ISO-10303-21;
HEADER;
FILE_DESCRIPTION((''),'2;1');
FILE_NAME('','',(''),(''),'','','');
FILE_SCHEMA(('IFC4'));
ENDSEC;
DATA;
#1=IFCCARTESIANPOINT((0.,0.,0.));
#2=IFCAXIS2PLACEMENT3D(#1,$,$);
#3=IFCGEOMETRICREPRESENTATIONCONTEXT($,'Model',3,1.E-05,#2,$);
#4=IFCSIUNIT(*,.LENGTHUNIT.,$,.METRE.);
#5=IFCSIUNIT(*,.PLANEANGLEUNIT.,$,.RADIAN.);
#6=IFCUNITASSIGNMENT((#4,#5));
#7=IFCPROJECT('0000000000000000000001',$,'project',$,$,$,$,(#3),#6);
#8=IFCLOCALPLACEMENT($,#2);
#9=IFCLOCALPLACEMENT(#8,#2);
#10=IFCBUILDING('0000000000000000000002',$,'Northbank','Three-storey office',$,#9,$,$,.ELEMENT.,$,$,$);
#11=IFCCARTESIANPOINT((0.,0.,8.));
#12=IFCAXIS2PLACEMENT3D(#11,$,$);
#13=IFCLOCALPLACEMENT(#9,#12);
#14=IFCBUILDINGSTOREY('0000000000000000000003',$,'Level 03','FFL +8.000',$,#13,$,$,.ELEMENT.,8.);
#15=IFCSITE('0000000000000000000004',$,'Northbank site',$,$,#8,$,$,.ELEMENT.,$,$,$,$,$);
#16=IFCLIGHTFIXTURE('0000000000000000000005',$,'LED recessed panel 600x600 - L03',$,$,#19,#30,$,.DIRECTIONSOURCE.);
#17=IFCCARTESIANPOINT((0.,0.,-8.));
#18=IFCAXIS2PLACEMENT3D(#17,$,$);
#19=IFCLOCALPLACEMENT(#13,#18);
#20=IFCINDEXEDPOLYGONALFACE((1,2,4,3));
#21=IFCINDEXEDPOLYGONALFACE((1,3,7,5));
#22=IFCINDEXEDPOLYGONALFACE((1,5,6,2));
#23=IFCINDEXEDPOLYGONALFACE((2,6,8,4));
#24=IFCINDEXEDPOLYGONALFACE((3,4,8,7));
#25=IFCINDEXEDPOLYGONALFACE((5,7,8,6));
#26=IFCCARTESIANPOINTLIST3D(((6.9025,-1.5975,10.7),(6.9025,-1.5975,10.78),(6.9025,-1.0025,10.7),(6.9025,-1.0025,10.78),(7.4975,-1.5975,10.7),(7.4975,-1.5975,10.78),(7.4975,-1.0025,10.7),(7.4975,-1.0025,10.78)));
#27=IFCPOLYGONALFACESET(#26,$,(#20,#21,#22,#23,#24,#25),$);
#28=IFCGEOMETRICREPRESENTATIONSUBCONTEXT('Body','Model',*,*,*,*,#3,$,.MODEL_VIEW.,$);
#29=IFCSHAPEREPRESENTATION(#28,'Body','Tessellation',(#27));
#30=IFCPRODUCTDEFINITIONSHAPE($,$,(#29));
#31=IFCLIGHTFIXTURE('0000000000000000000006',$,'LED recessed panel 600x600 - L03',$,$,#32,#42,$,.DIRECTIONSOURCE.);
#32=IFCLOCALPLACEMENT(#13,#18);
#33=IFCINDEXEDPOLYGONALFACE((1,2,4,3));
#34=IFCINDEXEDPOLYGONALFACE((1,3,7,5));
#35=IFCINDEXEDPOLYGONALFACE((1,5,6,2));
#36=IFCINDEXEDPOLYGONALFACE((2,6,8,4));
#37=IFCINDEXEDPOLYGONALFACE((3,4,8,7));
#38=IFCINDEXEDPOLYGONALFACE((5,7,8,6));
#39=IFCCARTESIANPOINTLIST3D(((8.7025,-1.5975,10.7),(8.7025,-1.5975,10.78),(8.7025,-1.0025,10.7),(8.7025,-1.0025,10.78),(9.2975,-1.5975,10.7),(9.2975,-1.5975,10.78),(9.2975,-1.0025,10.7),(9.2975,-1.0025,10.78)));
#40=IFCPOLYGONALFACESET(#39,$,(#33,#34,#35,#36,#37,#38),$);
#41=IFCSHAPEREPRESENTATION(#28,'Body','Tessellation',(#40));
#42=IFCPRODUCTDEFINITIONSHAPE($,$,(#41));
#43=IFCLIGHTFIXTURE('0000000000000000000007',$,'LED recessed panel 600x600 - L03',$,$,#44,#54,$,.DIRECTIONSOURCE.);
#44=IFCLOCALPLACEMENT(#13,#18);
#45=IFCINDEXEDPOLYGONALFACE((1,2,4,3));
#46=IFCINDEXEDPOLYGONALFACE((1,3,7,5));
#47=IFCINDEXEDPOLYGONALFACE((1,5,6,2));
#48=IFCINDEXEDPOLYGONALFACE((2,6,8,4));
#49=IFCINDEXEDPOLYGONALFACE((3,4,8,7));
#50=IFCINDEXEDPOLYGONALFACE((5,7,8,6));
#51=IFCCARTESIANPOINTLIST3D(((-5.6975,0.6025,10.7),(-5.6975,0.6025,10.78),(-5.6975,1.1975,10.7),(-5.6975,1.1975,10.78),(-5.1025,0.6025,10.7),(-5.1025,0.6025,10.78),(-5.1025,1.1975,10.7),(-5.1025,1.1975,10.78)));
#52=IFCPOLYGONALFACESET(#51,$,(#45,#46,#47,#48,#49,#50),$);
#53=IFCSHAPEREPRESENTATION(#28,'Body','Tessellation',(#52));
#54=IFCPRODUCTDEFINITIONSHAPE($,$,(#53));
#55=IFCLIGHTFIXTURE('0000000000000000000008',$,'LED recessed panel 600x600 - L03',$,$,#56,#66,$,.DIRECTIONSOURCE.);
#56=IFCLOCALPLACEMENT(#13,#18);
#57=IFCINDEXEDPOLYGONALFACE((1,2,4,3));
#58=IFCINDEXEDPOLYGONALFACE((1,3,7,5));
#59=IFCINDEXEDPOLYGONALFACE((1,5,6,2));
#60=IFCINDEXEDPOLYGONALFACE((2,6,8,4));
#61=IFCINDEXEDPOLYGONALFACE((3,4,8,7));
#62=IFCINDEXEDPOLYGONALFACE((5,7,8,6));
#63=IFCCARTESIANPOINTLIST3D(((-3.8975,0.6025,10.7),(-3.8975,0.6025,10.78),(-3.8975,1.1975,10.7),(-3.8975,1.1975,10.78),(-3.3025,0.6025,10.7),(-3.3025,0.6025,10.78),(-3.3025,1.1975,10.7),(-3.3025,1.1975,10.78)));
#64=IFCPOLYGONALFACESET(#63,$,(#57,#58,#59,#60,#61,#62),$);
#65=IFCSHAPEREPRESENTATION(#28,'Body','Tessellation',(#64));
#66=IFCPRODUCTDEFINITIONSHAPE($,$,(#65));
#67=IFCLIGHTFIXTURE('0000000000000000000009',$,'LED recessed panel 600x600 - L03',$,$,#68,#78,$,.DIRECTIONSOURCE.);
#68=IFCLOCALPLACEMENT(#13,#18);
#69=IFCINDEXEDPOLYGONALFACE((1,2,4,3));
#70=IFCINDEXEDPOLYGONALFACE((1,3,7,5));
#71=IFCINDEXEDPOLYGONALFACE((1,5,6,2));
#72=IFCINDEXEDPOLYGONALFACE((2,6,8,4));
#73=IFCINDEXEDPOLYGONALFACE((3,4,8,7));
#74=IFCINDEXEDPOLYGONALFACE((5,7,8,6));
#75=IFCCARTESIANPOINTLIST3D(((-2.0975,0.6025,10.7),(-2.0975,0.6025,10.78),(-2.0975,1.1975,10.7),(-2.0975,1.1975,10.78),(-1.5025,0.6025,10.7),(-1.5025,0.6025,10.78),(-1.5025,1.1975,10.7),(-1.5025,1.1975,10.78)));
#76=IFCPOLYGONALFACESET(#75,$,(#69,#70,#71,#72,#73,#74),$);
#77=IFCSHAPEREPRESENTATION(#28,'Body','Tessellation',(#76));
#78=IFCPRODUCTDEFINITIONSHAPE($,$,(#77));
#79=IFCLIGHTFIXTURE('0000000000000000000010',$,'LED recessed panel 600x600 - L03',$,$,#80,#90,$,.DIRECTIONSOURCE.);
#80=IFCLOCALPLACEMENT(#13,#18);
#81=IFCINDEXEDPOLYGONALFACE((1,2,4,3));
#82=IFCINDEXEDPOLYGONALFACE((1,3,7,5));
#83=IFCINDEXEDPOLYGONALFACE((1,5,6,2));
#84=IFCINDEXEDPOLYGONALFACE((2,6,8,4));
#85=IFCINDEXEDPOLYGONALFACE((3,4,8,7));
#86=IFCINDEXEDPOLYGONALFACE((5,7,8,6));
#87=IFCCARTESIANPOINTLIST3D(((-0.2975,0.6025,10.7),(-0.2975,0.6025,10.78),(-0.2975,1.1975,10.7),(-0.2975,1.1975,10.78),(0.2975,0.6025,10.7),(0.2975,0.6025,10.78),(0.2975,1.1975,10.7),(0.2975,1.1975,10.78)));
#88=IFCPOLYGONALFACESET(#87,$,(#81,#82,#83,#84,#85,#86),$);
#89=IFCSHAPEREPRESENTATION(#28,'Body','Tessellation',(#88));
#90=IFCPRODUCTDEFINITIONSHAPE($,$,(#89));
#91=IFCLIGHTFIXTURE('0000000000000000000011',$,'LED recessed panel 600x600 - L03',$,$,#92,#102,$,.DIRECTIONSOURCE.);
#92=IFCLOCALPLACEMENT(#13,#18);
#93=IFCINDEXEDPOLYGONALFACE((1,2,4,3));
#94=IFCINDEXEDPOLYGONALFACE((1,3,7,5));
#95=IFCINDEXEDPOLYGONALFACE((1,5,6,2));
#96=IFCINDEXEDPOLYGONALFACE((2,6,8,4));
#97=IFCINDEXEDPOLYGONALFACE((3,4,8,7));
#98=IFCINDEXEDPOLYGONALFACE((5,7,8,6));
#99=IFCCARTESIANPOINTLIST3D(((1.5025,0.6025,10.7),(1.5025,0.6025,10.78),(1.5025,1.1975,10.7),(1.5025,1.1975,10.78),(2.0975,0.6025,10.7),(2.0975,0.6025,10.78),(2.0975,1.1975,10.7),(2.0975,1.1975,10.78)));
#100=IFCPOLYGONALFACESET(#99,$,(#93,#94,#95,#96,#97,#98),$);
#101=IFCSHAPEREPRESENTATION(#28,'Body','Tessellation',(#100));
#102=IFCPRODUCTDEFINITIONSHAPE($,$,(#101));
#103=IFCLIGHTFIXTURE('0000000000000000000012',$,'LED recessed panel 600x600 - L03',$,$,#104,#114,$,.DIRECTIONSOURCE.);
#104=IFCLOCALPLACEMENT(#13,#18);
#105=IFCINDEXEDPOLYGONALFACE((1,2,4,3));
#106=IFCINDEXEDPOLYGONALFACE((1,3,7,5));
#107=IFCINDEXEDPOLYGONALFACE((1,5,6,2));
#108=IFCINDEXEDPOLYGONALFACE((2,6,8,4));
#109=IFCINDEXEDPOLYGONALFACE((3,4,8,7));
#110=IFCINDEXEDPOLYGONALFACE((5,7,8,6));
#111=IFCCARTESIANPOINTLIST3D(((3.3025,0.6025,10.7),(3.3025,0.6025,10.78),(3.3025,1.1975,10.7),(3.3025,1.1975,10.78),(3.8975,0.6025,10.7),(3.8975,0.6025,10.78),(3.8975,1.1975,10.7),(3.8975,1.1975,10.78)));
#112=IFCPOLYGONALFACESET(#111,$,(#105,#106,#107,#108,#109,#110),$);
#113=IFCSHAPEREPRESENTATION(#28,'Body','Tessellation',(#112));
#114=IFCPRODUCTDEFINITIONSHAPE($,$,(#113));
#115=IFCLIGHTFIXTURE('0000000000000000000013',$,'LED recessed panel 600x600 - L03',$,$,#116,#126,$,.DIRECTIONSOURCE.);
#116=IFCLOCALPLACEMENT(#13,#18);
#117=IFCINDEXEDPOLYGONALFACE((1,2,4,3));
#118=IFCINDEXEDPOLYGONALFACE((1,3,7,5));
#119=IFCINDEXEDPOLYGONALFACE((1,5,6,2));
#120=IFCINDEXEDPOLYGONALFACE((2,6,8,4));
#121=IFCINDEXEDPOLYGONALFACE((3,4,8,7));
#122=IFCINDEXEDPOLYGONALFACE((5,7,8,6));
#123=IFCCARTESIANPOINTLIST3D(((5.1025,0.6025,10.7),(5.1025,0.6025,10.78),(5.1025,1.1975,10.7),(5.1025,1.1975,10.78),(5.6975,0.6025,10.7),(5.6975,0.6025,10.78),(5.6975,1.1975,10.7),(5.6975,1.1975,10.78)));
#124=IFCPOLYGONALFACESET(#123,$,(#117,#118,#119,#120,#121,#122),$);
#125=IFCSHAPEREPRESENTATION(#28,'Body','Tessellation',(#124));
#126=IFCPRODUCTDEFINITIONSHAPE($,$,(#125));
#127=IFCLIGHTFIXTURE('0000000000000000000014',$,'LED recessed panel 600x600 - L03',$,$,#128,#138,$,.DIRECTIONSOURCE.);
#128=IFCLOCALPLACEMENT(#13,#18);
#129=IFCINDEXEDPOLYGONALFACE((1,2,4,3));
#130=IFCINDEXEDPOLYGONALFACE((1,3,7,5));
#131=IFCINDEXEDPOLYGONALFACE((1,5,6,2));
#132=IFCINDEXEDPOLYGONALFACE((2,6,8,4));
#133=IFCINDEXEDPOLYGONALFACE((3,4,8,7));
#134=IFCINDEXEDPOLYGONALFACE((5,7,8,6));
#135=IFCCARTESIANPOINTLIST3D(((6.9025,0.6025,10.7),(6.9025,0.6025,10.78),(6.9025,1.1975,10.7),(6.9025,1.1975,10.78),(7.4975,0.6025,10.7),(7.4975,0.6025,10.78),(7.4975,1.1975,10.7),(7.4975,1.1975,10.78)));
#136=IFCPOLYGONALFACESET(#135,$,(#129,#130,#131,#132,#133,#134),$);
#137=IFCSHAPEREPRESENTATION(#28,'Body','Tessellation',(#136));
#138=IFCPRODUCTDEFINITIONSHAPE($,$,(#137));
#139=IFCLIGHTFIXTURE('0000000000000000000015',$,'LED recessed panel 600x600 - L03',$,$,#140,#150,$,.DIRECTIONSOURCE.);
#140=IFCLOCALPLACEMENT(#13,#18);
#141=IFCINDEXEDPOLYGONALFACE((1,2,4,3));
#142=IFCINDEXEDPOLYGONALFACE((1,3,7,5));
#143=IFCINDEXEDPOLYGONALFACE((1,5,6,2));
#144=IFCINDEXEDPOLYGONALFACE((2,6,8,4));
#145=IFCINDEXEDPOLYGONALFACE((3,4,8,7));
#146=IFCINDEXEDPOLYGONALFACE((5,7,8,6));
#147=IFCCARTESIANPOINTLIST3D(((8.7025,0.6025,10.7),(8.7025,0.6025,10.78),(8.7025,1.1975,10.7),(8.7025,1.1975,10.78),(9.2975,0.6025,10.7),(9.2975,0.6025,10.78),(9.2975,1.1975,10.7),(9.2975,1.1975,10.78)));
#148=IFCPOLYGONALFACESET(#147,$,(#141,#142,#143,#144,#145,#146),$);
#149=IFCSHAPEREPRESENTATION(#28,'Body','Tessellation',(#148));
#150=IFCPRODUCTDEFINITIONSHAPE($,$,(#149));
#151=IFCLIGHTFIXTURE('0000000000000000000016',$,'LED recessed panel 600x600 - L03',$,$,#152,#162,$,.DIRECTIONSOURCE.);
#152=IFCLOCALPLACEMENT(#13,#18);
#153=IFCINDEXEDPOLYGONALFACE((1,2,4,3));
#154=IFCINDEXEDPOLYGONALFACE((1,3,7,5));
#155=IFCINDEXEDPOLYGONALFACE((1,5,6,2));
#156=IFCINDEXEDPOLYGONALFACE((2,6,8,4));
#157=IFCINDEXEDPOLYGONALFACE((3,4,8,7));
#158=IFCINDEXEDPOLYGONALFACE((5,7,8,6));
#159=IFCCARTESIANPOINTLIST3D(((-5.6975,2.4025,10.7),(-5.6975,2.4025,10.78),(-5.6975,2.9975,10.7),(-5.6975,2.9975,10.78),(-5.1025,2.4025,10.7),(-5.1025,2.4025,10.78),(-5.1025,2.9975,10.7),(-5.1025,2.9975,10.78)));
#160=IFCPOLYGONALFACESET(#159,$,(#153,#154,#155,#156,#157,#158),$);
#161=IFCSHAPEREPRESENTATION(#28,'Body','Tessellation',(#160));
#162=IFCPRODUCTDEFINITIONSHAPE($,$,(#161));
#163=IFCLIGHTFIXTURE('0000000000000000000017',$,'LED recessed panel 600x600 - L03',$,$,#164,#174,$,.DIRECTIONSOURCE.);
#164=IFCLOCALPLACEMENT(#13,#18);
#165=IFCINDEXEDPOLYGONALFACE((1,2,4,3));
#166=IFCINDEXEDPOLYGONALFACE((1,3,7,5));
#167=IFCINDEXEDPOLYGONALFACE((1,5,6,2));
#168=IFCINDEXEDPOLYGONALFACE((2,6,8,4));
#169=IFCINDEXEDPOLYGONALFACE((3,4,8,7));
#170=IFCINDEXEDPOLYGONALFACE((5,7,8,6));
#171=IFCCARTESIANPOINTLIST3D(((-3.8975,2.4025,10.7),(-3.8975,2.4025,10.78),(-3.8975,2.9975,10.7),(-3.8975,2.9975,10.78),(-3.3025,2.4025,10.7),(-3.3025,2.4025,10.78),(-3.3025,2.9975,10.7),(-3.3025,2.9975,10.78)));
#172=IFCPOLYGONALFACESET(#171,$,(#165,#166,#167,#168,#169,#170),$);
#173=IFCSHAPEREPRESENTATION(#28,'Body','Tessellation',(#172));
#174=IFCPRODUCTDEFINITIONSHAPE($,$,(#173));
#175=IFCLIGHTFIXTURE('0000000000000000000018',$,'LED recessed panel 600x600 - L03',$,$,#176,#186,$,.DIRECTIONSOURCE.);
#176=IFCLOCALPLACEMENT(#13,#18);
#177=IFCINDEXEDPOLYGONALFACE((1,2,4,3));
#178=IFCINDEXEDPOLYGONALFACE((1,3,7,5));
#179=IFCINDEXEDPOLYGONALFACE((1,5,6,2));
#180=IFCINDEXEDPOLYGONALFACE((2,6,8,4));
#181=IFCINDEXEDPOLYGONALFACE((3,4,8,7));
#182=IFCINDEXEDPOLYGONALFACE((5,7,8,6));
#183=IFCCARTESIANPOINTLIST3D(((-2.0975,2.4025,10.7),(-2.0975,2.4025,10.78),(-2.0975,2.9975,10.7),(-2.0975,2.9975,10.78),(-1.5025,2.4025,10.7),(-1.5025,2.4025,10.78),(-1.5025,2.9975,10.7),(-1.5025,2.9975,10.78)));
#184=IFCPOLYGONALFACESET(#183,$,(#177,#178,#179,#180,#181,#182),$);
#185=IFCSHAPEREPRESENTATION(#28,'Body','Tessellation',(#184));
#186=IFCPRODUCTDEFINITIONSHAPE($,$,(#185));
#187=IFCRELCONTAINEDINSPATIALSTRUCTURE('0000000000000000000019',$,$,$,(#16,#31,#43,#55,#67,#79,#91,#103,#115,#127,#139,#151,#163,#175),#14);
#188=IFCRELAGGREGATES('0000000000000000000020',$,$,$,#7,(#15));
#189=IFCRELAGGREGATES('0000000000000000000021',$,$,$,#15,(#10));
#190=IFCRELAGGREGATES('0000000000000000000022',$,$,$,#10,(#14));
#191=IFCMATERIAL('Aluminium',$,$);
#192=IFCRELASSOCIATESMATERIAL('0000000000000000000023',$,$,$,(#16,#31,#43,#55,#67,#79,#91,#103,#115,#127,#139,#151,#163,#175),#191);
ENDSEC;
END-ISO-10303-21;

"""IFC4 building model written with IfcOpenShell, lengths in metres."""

from ifc_helpers import new_model, si_unit, frame, origin, place, context, subcontext, project, spatial, rectangle, extrude, material, element, save


model = new_model("IFC4")

# Units and contexts
model_context = context("Model", 3, precision=1e-05, world=origin())
body_context = subcontext(model_context, "Body", "Model", "MODEL_VIEW")
ifc_project = project(units=[si_unit("LENGTHUNIT", "METRE"), si_unit("PLANEANGLEUNIT", "RADIAN")], contexts=[model_context])

# Site, building, storey
site_placement = place(None, origin())
site = spatial("IfcSite", under=ifc_project, at=site_placement, Name="Northbank site", CompositionType="ELEMENT")
building_placement = place(site_placement, origin())
building = spatial("IfcBuilding", under=site, at=building_placement, Name="Northbank", Description="Three-storey office", CompositionType="ELEMENT")
storey_placement = place(building_placement, frame((0.0, 0.0, 8.0)))
storey = spatial("IfcBuildingStorey", under=building, at=storey_placement, Name="Level 03", Description="FFL +8.000", CompositionType="ELEMENT", Elevation=8.0)

# Light fixtures
ifc_material = material(Name="Aluminium")
light_fixture_1_placement = place(storey_placement, frame((0.0, 0.0, -8.0)))
element("IfcLightFixture", 1, at=light_fixture_1_placement, inside=storey, material=ifc_material, Name="LED recessed panel 600x600 - L03", PredefinedType="DIRECTIONSOURCE", context=body_context, shape_type="SweptSolid", body=[
    extrude(rectangle(XDim=0.595, YDim=0.595), frame((7.2, -1.3, 10.7)), (0.0, 0.0, 1.0), 0.08),
])
light_fixture_2_placement = place(storey_placement, frame((0.0, 0.0, -8.0)))
element("IfcLightFixture", 2, at=light_fixture_2_placement, inside=storey, material=ifc_material, Name="LED recessed panel 600x600 - L03", PredefinedType="DIRECTIONSOURCE", context=body_context, shape_type="SweptSolid", body=[
    extrude(rectangle(XDim=0.595, YDim=0.595), frame((9.0, -1.3, 10.7)), (0.0, 0.0, 1.0), 0.08),
])
light_fixture_3_placement = place(storey_placement, frame((0.0, 0.0, -8.0)))
element("IfcLightFixture", 3, at=light_fixture_3_placement, inside=storey, material=ifc_material, Name="LED recessed panel 600x600 - L03", PredefinedType="DIRECTIONSOURCE", context=body_context, shape_type="SweptSolid", body=[
    extrude(rectangle(XDim=0.595, YDim=0.595), frame((-5.4, 0.9, 10.7)), (0.0, 0.0, 1.0), 0.08),
])
light_fixture_4_placement = place(storey_placement, frame((0.0, 0.0, -8.0)))
element("IfcLightFixture", 4, at=light_fixture_4_placement, inside=storey, material=ifc_material, Name="LED recessed panel 600x600 - L03", PredefinedType="DIRECTIONSOURCE", context=body_context, shape_type="SweptSolid", body=[
    extrude(rectangle(XDim=0.595, YDim=0.595), frame((-3.6, 0.9, 10.7)), (0.0, 0.0, 1.0), 0.08),
])
light_fixture_5_placement = place(storey_placement, frame((0.0, 0.0, -8.0)))
element("IfcLightFixture", 5, at=light_fixture_5_placement, inside=storey, material=ifc_material, Name="LED recessed panel 600x600 - L03", PredefinedType="DIRECTIONSOURCE", context=body_context, shape_type="SweptSolid", body=[
    extrude(rectangle(XDim=0.595, YDim=0.595), frame((-1.8, 0.9, 10.7)), (0.0, 0.0, 1.0), 0.08),
])
light_fixture_6_placement = place(storey_placement, frame((0.0, 0.0, -8.0)))
element("IfcLightFixture", 6, at=light_fixture_6_placement, inside=storey, material=ifc_material, Name="LED recessed panel 600x600 - L03", PredefinedType="DIRECTIONSOURCE", context=body_context, shape_type="SweptSolid", body=[
    extrude(rectangle(XDim=0.595, YDim=0.595), frame((0.0, 0.9, 10.7)), (0.0, 0.0, 1.0), 0.08),
])
light_fixture_7_placement = place(storey_placement, frame((0.0, 0.0, -8.0)))
element("IfcLightFixture", 7, at=light_fixture_7_placement, inside=storey, material=ifc_material, Name="LED recessed panel 600x600 - L03", PredefinedType="DIRECTIONSOURCE", context=body_context, shape_type="SweptSolid", body=[
    extrude(rectangle(XDim=0.595, YDim=0.595), frame((1.8, 0.9, 10.7)), (0.0, 0.0, 1.0), 0.08),
])
light_fixture_8_placement = place(storey_placement, frame((0.0, 0.0, -8.0)))
element("IfcLightFixture", 8, at=light_fixture_8_placement, inside=storey, material=ifc_material, Name="LED recessed panel 600x600 - L03", PredefinedType="DIRECTIONSOURCE", context=body_context, shape_type="SweptSolid", body=[
    extrude(rectangle(XDim=0.595, YDim=0.595), frame((3.6, 0.9, 10.7)), (0.0, 0.0, 1.0), 0.08),
])
light_fixture_9_placement = place(storey_placement, frame((0.0, 0.0, -8.0)))
element("IfcLightFixture", 9, at=light_fixture_9_placement, inside=storey, material=ifc_material, Name="LED recessed panel 600x600 - L03", PredefinedType="DIRECTIONSOURCE", context=body_context, shape_type="SweptSolid", body=[
    extrude(rectangle(XDim=0.595, YDim=0.595), frame((5.4, 0.9, 10.7)), (0.0, 0.0, 1.0), 0.08),
])
light_fixture_10_placement = place(storey_placement, frame((0.0, 0.0, -8.0)))
element("IfcLightFixture", 10, at=light_fixture_10_placement, inside=storey, material=ifc_material, Name="LED recessed panel 600x600 - L03", PredefinedType="DIRECTIONSOURCE", context=body_context, shape_type="SweptSolid", body=[
    extrude(rectangle(XDim=0.595, YDim=0.595), frame((7.2, 0.9, 10.7)), (0.0, 0.0, 1.0), 0.08),
])
light_fixture_11_placement = place(storey_placement, frame((0.0, 0.0, -8.0)))
element("IfcLightFixture", 11, at=light_fixture_11_placement, inside=storey, material=ifc_material, Name="LED recessed panel 600x600 - L03", PredefinedType="DIRECTIONSOURCE", context=body_context, shape_type="SweptSolid", body=[
    extrude(rectangle(XDim=0.595, YDim=0.595), frame((9.0, 0.9, 10.7)), (0.0, 0.0, 1.0), 0.08),
])
light_fixture_12_placement = place(storey_placement, frame((0.0, 0.0, -8.0)))
element("IfcLightFixture", 12, at=light_fixture_12_placement, inside=storey, material=ifc_material, Name="LED recessed panel 600x600 - L03", PredefinedType="DIRECTIONSOURCE", context=body_context, shape_type="SweptSolid", body=[
    extrude(rectangle(XDim=0.595, YDim=0.595), frame((-5.4, 2.7, 10.7)), (0.0, 0.0, 1.0), 0.08),
])
light_fixture_13_placement = place(storey_placement, frame((0.0, 0.0, -8.0)))
element("IfcLightFixture", 13, at=light_fixture_13_placement, inside=storey, material=ifc_material, Name="LED recessed panel 600x600 - L03", PredefinedType="DIRECTIONSOURCE", context=body_context, shape_type="SweptSolid", body=[
    extrude(rectangle(XDim=0.595, YDim=0.595), frame((-3.6, 2.7, 10.7)), (0.0, 0.0, 1.0), 0.08),
])
light_fixture_14_placement = place(storey_placement, frame((0.0, 0.0, -8.0)))
element("IfcLightFixture", 14, at=light_fixture_14_placement, inside=storey, material=ifc_material, Name="LED recessed panel 600x600 - L03", PredefinedType="DIRECTIONSOURCE", context=body_context, shape_type="SweptSolid", body=[
    extrude(rectangle(XDim=0.595, YDim=0.595), frame((-1.8, 2.7, 10.7)), (0.0, 0.0, 1.0), 0.08),
])

save(model, "model.ifc")
